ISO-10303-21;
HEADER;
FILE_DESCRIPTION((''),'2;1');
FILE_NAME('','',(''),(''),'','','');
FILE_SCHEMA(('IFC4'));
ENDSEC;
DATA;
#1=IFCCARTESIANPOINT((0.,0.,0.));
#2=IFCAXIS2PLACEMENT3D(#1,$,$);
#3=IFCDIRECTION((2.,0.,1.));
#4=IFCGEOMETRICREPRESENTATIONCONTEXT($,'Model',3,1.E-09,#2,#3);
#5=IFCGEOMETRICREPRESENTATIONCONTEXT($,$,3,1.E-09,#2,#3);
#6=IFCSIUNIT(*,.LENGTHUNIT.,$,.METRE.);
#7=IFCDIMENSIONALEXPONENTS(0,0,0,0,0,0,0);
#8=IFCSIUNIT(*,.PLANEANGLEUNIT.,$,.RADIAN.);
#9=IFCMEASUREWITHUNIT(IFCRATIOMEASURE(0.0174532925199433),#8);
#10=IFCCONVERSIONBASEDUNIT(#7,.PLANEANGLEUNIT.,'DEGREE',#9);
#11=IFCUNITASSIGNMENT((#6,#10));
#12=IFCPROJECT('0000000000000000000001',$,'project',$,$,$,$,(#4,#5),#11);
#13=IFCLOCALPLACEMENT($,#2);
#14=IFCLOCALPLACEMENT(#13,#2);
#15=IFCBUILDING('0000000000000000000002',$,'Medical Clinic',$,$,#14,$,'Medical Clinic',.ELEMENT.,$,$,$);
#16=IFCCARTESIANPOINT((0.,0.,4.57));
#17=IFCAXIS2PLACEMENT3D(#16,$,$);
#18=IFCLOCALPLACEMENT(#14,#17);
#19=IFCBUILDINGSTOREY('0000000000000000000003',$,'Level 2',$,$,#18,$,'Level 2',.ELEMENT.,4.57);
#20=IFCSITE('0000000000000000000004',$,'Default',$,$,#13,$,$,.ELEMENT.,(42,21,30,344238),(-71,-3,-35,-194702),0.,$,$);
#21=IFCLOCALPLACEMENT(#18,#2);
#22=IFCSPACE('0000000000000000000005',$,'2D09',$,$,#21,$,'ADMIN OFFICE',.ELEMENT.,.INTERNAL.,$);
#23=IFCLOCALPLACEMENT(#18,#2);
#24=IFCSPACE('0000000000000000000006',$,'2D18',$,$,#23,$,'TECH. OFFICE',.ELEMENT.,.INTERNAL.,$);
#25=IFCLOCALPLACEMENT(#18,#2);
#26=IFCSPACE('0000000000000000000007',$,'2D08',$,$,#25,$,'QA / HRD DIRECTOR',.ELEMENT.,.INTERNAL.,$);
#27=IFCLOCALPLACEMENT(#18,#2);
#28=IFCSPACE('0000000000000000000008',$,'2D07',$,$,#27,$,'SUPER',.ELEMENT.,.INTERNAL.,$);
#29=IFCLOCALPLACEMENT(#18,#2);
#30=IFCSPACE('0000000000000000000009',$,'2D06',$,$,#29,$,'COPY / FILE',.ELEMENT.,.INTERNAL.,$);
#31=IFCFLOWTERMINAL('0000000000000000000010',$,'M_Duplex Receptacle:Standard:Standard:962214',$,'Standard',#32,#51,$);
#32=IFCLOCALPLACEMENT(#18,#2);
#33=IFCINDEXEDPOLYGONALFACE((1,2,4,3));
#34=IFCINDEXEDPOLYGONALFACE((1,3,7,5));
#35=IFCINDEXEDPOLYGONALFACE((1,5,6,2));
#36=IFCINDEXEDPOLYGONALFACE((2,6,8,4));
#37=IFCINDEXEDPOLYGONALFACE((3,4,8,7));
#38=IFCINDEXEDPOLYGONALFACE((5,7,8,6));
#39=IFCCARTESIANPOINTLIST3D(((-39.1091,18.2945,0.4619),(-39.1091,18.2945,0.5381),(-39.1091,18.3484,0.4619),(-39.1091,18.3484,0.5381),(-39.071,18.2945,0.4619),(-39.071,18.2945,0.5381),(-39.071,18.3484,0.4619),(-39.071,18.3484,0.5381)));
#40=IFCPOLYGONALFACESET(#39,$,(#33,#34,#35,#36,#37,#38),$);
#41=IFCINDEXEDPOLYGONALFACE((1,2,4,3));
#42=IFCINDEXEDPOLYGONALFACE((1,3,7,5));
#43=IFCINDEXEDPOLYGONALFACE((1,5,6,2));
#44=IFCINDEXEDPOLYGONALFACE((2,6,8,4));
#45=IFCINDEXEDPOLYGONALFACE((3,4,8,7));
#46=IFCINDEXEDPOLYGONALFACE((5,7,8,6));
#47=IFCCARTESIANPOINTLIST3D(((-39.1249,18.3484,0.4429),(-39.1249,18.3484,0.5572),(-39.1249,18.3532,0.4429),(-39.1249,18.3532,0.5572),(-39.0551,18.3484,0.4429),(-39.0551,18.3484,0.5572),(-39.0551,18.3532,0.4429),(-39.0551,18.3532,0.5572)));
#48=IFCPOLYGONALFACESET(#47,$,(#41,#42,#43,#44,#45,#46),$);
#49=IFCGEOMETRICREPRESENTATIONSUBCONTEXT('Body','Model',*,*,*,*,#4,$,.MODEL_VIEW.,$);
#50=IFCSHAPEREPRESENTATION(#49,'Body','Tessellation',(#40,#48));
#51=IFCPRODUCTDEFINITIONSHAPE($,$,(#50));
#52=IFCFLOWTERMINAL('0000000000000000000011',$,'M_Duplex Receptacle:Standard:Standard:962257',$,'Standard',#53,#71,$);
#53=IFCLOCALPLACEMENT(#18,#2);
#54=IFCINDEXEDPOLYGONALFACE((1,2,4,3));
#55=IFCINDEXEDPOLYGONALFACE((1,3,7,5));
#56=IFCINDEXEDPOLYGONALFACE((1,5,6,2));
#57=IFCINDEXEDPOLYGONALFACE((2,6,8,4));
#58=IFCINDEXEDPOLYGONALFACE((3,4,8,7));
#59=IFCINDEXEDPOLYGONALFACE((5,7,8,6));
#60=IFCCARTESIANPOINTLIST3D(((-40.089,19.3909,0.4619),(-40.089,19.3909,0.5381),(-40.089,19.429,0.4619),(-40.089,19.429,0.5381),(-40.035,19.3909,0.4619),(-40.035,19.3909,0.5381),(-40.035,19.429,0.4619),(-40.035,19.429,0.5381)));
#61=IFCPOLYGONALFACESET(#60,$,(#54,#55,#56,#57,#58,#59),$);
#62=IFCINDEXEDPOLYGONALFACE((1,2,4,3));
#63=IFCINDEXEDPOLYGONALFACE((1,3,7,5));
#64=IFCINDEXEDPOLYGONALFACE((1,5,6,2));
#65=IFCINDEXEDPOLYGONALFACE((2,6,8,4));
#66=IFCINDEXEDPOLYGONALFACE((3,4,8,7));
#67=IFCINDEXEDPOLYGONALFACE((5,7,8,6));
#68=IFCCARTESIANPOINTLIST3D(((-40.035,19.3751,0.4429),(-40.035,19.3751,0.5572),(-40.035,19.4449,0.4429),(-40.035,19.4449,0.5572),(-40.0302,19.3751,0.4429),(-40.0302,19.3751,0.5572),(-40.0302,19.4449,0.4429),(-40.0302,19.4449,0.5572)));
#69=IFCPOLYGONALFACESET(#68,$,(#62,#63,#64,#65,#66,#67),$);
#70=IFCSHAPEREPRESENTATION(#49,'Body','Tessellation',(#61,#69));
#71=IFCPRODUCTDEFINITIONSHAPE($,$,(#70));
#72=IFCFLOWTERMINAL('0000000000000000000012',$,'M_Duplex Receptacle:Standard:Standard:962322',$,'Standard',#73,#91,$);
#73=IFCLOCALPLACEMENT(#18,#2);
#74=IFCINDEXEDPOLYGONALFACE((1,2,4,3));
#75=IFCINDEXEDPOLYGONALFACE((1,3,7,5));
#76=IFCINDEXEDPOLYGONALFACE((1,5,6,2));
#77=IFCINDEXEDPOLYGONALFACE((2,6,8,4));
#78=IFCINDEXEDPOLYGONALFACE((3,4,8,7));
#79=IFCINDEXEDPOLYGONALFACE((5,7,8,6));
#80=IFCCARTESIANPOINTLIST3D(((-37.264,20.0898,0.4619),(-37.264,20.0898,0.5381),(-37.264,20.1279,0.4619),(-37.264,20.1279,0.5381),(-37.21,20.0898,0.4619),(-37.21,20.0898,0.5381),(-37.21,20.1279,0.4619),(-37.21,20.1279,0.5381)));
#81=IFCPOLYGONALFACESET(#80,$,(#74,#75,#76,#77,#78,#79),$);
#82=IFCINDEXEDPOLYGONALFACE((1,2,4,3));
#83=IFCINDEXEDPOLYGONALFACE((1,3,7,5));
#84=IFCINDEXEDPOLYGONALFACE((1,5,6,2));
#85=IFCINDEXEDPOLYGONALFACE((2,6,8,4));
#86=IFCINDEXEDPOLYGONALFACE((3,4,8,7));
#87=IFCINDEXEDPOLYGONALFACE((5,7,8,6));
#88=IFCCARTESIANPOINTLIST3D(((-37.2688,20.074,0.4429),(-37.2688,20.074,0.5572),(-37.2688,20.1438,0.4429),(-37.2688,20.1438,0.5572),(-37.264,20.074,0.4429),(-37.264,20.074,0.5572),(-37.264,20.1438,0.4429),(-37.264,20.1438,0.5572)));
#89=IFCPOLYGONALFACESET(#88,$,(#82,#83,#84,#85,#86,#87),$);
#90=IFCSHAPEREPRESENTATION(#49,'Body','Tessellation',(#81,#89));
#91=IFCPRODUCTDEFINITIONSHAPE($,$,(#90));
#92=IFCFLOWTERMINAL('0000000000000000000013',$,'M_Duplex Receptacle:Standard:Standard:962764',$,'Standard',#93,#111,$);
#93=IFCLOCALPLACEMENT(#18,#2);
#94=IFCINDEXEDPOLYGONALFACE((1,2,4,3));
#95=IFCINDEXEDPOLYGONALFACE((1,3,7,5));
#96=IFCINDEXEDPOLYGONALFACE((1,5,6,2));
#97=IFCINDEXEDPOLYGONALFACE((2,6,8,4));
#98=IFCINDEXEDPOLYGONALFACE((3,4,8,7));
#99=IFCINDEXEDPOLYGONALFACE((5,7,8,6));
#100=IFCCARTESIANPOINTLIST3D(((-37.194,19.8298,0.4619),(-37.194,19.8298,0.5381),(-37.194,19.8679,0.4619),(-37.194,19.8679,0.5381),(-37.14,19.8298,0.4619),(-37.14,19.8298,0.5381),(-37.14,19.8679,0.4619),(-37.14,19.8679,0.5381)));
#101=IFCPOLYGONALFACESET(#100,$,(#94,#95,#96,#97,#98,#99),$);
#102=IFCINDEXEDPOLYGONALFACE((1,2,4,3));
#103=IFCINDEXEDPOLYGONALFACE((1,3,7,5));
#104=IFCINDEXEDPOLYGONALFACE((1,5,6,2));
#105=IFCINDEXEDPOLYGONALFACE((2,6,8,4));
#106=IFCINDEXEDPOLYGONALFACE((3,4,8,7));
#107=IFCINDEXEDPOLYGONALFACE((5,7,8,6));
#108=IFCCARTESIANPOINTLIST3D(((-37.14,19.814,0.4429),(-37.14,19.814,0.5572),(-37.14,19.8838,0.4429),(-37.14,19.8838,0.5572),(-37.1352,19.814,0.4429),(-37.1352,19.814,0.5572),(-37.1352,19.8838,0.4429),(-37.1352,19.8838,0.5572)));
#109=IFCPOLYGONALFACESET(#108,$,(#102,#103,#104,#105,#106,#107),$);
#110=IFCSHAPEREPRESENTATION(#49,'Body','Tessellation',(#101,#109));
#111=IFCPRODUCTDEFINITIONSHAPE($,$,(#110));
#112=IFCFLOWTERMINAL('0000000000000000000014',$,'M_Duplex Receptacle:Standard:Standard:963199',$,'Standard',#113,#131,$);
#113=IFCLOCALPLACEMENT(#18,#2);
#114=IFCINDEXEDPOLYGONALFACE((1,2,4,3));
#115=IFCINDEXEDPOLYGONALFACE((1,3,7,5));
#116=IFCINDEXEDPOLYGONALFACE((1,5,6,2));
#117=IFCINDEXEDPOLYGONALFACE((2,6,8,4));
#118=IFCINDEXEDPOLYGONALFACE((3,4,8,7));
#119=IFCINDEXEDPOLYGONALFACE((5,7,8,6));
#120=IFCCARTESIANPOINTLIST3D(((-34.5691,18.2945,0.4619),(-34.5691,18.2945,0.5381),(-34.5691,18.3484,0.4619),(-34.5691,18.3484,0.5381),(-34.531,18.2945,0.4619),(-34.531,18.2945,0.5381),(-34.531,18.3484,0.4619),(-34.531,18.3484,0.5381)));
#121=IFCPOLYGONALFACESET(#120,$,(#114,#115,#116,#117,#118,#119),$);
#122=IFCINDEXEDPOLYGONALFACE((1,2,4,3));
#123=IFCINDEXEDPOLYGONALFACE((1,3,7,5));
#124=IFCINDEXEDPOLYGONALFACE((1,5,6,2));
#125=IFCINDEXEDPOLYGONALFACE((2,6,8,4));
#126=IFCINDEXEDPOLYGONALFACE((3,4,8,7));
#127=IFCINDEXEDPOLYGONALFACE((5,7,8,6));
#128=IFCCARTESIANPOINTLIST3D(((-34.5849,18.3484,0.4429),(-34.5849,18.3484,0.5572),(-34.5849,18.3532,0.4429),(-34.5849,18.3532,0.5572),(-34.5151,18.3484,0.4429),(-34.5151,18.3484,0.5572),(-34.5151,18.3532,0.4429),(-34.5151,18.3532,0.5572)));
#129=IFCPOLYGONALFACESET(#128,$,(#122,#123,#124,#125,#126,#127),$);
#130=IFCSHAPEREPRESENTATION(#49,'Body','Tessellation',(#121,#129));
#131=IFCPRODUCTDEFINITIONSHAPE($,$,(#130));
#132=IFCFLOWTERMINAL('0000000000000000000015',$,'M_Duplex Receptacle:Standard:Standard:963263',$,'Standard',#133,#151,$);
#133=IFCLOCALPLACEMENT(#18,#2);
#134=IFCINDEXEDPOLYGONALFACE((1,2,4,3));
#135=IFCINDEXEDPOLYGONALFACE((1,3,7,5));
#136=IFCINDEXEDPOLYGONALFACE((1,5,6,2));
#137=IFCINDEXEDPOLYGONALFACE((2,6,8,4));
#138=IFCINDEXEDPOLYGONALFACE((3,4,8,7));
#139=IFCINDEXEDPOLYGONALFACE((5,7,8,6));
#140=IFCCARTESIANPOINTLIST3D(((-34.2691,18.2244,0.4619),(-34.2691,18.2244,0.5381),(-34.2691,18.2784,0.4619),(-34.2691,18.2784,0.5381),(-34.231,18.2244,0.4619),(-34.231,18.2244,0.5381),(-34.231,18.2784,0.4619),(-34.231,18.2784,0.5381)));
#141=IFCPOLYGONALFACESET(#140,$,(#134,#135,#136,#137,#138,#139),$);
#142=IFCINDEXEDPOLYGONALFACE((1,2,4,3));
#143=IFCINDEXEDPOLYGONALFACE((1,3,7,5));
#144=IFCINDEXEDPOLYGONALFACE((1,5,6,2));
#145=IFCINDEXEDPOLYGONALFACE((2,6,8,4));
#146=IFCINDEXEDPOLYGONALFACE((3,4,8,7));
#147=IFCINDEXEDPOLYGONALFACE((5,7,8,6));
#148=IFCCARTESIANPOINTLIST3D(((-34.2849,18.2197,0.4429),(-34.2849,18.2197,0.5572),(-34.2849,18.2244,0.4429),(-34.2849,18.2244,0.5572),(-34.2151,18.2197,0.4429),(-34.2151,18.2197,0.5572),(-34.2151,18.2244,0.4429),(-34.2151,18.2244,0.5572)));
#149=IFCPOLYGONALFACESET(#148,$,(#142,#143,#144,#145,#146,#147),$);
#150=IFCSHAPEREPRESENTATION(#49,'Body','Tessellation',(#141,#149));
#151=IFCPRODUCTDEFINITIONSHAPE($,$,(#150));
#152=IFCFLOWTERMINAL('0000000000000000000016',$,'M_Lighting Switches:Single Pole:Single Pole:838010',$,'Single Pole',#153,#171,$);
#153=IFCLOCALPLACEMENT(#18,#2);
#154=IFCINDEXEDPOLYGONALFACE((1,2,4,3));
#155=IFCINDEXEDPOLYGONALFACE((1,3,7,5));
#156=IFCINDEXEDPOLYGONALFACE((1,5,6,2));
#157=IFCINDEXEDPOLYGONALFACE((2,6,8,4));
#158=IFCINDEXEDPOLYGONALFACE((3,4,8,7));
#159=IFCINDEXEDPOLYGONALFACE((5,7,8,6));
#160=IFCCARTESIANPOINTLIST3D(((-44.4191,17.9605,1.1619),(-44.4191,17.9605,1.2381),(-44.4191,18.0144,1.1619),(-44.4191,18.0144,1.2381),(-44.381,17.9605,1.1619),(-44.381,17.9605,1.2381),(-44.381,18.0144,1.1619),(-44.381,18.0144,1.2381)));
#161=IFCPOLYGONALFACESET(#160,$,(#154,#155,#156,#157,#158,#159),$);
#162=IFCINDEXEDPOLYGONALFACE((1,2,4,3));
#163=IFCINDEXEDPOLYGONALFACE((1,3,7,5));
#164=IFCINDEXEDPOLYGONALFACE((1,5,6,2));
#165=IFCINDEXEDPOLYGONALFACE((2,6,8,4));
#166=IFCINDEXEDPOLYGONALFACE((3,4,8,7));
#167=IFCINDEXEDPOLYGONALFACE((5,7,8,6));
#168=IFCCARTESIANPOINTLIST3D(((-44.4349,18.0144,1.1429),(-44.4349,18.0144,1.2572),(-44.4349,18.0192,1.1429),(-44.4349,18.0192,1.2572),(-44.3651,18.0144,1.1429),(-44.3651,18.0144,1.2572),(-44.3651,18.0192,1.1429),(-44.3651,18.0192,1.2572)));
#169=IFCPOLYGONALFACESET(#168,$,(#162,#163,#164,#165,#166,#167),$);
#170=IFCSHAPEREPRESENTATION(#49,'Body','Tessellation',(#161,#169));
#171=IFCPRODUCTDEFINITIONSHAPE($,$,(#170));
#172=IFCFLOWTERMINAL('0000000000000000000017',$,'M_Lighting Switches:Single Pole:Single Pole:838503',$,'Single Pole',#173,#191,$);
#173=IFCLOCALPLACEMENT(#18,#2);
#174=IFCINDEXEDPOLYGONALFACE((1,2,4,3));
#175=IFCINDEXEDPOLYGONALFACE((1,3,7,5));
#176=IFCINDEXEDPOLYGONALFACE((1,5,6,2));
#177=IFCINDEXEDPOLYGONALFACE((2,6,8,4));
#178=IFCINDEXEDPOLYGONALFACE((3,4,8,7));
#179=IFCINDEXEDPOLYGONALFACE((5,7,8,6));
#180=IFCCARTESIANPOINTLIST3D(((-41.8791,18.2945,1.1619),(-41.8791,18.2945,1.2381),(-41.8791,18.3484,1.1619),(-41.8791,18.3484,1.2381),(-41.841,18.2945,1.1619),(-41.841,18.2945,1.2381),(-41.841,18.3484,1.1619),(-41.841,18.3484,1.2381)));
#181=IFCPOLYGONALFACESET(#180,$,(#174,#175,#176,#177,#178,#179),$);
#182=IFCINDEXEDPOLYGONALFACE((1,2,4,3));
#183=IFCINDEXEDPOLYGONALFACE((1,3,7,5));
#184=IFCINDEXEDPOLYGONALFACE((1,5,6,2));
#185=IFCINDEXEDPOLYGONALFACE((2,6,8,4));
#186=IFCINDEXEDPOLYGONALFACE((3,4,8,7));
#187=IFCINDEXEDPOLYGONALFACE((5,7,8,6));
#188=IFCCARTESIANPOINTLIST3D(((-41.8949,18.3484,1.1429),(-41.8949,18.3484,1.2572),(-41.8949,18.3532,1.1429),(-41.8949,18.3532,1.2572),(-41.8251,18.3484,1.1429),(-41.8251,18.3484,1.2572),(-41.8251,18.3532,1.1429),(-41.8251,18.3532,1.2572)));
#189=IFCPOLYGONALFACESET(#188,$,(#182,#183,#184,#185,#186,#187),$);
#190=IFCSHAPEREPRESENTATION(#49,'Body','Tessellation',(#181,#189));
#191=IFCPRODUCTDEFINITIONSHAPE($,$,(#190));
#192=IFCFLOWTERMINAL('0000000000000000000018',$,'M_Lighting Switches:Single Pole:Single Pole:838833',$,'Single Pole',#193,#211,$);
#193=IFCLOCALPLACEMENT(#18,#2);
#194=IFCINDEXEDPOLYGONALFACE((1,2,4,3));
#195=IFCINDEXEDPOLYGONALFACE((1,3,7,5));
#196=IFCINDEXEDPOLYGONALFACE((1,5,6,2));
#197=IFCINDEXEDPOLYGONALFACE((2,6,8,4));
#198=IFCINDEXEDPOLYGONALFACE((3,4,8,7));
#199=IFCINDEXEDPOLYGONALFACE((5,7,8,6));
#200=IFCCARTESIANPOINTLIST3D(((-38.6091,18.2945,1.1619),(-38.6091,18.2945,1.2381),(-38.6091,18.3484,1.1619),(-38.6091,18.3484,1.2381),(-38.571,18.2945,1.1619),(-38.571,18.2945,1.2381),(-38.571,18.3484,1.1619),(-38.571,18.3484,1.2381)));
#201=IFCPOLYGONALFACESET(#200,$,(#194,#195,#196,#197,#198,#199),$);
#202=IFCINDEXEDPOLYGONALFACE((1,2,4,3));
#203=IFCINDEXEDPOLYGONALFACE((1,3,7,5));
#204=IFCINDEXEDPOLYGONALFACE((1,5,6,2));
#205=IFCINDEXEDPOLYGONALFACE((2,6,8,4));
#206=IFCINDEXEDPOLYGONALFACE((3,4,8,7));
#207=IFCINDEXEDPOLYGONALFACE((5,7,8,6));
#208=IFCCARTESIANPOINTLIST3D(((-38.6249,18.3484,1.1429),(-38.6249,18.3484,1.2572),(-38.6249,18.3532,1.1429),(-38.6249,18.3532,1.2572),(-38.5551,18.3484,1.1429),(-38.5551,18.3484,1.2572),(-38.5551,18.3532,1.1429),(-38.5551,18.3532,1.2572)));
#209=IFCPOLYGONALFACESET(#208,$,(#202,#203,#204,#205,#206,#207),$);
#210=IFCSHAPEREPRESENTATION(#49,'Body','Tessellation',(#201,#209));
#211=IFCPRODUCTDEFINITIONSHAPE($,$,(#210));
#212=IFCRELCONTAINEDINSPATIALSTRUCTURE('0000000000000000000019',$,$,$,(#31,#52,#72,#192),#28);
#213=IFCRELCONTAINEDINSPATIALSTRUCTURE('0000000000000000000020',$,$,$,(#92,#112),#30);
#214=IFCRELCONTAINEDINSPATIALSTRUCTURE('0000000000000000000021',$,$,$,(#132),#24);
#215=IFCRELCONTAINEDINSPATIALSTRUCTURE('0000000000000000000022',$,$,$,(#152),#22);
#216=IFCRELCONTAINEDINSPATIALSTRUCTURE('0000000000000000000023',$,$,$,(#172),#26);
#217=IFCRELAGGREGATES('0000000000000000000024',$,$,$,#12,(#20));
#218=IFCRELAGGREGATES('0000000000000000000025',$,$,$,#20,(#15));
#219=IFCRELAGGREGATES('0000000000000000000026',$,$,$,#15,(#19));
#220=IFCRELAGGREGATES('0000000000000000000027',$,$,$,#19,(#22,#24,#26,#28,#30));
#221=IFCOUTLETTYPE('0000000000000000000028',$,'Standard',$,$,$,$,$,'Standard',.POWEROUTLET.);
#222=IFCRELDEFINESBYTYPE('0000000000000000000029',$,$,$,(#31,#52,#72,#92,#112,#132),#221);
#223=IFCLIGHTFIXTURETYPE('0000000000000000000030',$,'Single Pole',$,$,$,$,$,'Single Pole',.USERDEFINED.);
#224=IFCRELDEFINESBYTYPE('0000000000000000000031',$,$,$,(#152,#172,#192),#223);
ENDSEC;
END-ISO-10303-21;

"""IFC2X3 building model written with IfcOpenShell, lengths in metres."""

from ifc_helpers import new_model, entity, si_unit, converted_unit, direction, frame, frame_2d, origin, origin_2d_with_axis, place, context, subcontext, project, spatial, rectangle, extrude, source, transform, mapped, type_object, type_shapes, element, save


model = new_model("IFC2X3")

# Units and contexts
model_context = context("Model", 3, precision=1e-09, world=origin(), true_north=direction((2.0, 0.0, 1.0)))
context_of_model = context(None, 3, precision=1e-09, world=origin(), true_north=direction((2.0, 0.0, 1.0)))
body_context = subcontext(model_context, "Body", "Model", "MODEL_VIEW")
ifc_project = project(units=[si_unit("LENGTHUNIT", "METRE"), converted_unit("PLANEANGLEUNIT", "DEGREE", entity("IfcRatioMeasure", 0.0174532925199433), si_unit("PLANEANGLEUNIT", "RADIAN"), dimensions=[0, 0, 0, 0, 0, 0, 0])], contexts=[model_context, context_of_model])

# Site, building, storey
site_placement = place(None, origin())
site = spatial("IfcSite", under=ifc_project, at=site_placement, Name="Default", CompositionType="ELEMENT", RefLatitude=(42, 21, 30, 344238), RefLongitude=(-71, -3, -35, -194702), RefElevation=0.0)
building_placement = place(site_placement, origin())
building = spatial("IfcBuilding", under=site, at=building_placement, Name="Medical Clinic", LongName="Medical Clinic", CompositionType="ELEMENT")
storey_placement = place(building_placement, frame((0.0, 0.0, 4.57)))
storey = spatial("IfcBuildingStorey", under=building, at=storey_placement, Name="Level 2", LongName="Level 2", CompositionType="ELEMENT", Elevation=4.57)

# Shared definitions
outlet_type = type_object("IfcOutletType", Name="Standard", ElementType="Standard", PredefinedType="POWEROUTLET")
shared_shape_1 = source(origin(), body_context, "Body", "SweptSolid", [
    extrude(rectangle(XDim=0.0381, YDim=0.0762, at=origin_2d_with_axis()), frame((0.0, 0.0, -0.054), z_axis=(0.0, 0.0, 1.0), x_axis=(-1.0, 0.0, 0.0)), (0.0, 0.0, 1.0), 0.054),
    extrude(rectangle(XDim=0.0698, YDim=0.1143, at=frame_2d((0.0, 0.0), x_axis=(1.0, 0.0))), frame((0.0, 0.0, 0.0), z_axis=(0.0, 0.0, 1.0), x_axis=(-1.0, 0.0, 0.0)), (0.0, 0.0, 1.0), 0.0048),
])
type_shapes(outlet_type, [shared_shape_1])

# Shared definitions
space_1_placement = place(storey_placement, origin())
space_1 = spatial("IfcSpace", under=storey, at=space_1_placement, Name="2D09", LongName="ADMIN OFFICE", CompositionType="ELEMENT", InteriorOrExteriorSpace="INTERNAL")

# Shared definitions
space_2_placement = place(storey_placement, origin())
space_2 = spatial("IfcSpace", under=storey, at=space_2_placement, Name="2D18", LongName="TECH. OFFICE", CompositionType="ELEMENT", InteriorOrExteriorSpace="INTERNAL")

# Shared definitions
space_3_placement = place(storey_placement, origin())
space_3 = spatial("IfcSpace", under=storey, at=space_3_placement, Name="2D08", LongName="QA / HRD DIRECTOR", CompositionType="ELEMENT", InteriorOrExteriorSpace="INTERNAL")

# Shared definitions
space_4_placement = place(storey_placement, origin())
space_4 = spatial("IfcSpace", under=storey, at=space_4_placement, Name="2D07", LongName="SUPER", CompositionType="ELEMENT", InteriorOrExteriorSpace="INTERNAL")

# Flow terminals
for number, where, z_axis, x_axis, name in (
    (1, (-39.09, 18.3484, 0.5), (0.0, 1.0, 0.0), (-1.0, 0.0, 0.0), "M_Duplex Receptacle:Standard:Standard:962214"),
    (2, (-40.035, 19.41, 0.5), (1.0, 0.0, 0.0), (0.0, 1.0, 0.0), "M_Duplex Receptacle:Standard:Standard:962257"),
    (3, (-37.264, 20.1089, 0.5), (-1.0, 0.0, 0.0), (0.0, -1.0, 0.0), "M_Duplex Receptacle:Standard:Standard:962322"),
):
    element("IfcFlowTerminal", number, at=place(space_4_placement, frame(where, z_axis=z_axis, x_axis=x_axis)), inside=space_4, type_object=outlet_type, Name=name, ObjectType="Standard", context=body_context, shape_type="MappedRepresentation", body=[
        mapped(shared_shape_1, transform((0.0, 0.0, 0.0), scale=1.0)),
    ])

# Shared definitions
space_5_placement = place(storey_placement, origin())
space_5 = spatial("IfcSpace", under=storey, at=space_5_placement, Name="2D06", LongName="COPY / FILE", CompositionType="ELEMENT", InteriorOrExteriorSpace="INTERNAL")

# Flow terminals
for number, where, z_axis, x_axis, name in (
    (4, (-37.14, 19.8489, 0.5), (1.0, 0.0, 0.0), (0.0, 1.0, 0.0), "M_Duplex Receptacle:Standard:Standard:962764"),
    (5, (-34.55, 18.3484, 0.5), (0.0, 1.0, 0.0), (-1.0, 0.0, 0.0), "M_Duplex Receptacle:Standard:Standard:963199"),
):
    element("IfcFlowTerminal", number, at=place(space_5_placement, frame(where, z_axis=z_axis, x_axis=x_axis)), inside=space_5, type_object=outlet_type, Name=name, ObjectType="Standard", context=body_context, shape_type="MappedRepresentation", body=[
        mapped(shared_shape_1, transform((0.0, 0.0, 0.0), scale=1.0)),
    ])
flow_terminal_1_placement = place(space_2_placement, frame((-34.25, 18.2244, 0.5), z_axis=(0.0, -1.0, 0.0), x_axis=(1.0, 0.0, 0.0)))
element("IfcFlowTerminal", 6, at=flow_terminal_1_placement, inside=space_2, type_object=outlet_type, Name="M_Duplex Receptacle:Standard:Standard:963263", ObjectType="Standard", context=body_context, shape_type="MappedRepresentation", body=[
    mapped(shared_shape_1, transform((0.0, 0.0, 0.0), scale=1.0)),
])
light_fixture_type_1 = type_object("IfcLightFixtureType", Name="Single Pole", ElementType="Single Pole", PredefinedType="USERDEFINED")
shared_shape_2 = source(origin(), body_context, "Body", "SweptSolid", [
    extrude(rectangle(XDim=0.0381, YDim=0.0762, at=origin_2d_with_axis()), frame((0.0, 0.0, -0.054), z_axis=(0.0, 0.0, 1.0), x_axis=(-1.0, 0.0, 0.0)), (0.0, 0.0, 1.0), 0.054),
    extrude(rectangle(XDim=0.0698, YDim=0.1143, at=frame_2d((0.0, 0.0), x_axis=(1.0, 0.0))), frame((0.0, 0.0, 0.0), z_axis=(0.0, 0.0, 1.0), x_axis=(-1.0, 0.0, 0.0)), (0.0, 0.0, 1.0), 0.0048),
])
type_shapes(light_fixture_type_1, [shared_shape_2])
flow_terminal_2_placement = place(space_1_placement, frame((-44.4, 18.0144, 1.2), z_axis=(0.0, 1.0, 0.0), x_axis=(-1.0, 0.0, 0.0)))
element("IfcFlowTerminal", 7, at=flow_terminal_2_placement, inside=space_1, type_object=light_fixture_type_1, Name="M_Lighting Switches:Single Pole:Single Pole:838010", ObjectType="Single Pole", context=body_context, shape_type="MappedRepresentation", body=[
    mapped(shared_shape_2, transform((0.0, 0.0, 0.0), scale=1.0)),
])
flow_terminal_3_placement = place(space_3_placement, frame((-41.86, 18.3484, 1.2), z_axis=(0.0, 1.0, 0.0), x_axis=(-1.0, 0.0, 0.0)))
element("IfcFlowTerminal", 8, at=flow_terminal_3_placement, inside=space_3, type_object=light_fixture_type_1, Name="M_Lighting Switches:Single Pole:Single Pole:838503", ObjectType="Single Pole", context=body_context, shape_type="MappedRepresentation", body=[
    mapped(shared_shape_2, transform((0.0, 0.0, 0.0), scale=1.0)),
])
flow_terminal_4_placement = place(space_4_placement, frame((-38.59, 18.3484, 1.2), z_axis=(0.0, 1.0, 0.0), x_axis=(-1.0, 0.0, 0.0)))
element("IfcFlowTerminal", 9, at=flow_terminal_4_placement, inside=space_4, type_object=light_fixture_type_1, Name="M_Lighting Switches:Single Pole:Single Pole:838833", ObjectType="Single Pole", context=body_context, shape_type="MappedRepresentation", body=[
    mapped(shared_shape_2, transform((0.0, 0.0, 0.0), scale=1.0)),
])

save(model, "model.ifc")
